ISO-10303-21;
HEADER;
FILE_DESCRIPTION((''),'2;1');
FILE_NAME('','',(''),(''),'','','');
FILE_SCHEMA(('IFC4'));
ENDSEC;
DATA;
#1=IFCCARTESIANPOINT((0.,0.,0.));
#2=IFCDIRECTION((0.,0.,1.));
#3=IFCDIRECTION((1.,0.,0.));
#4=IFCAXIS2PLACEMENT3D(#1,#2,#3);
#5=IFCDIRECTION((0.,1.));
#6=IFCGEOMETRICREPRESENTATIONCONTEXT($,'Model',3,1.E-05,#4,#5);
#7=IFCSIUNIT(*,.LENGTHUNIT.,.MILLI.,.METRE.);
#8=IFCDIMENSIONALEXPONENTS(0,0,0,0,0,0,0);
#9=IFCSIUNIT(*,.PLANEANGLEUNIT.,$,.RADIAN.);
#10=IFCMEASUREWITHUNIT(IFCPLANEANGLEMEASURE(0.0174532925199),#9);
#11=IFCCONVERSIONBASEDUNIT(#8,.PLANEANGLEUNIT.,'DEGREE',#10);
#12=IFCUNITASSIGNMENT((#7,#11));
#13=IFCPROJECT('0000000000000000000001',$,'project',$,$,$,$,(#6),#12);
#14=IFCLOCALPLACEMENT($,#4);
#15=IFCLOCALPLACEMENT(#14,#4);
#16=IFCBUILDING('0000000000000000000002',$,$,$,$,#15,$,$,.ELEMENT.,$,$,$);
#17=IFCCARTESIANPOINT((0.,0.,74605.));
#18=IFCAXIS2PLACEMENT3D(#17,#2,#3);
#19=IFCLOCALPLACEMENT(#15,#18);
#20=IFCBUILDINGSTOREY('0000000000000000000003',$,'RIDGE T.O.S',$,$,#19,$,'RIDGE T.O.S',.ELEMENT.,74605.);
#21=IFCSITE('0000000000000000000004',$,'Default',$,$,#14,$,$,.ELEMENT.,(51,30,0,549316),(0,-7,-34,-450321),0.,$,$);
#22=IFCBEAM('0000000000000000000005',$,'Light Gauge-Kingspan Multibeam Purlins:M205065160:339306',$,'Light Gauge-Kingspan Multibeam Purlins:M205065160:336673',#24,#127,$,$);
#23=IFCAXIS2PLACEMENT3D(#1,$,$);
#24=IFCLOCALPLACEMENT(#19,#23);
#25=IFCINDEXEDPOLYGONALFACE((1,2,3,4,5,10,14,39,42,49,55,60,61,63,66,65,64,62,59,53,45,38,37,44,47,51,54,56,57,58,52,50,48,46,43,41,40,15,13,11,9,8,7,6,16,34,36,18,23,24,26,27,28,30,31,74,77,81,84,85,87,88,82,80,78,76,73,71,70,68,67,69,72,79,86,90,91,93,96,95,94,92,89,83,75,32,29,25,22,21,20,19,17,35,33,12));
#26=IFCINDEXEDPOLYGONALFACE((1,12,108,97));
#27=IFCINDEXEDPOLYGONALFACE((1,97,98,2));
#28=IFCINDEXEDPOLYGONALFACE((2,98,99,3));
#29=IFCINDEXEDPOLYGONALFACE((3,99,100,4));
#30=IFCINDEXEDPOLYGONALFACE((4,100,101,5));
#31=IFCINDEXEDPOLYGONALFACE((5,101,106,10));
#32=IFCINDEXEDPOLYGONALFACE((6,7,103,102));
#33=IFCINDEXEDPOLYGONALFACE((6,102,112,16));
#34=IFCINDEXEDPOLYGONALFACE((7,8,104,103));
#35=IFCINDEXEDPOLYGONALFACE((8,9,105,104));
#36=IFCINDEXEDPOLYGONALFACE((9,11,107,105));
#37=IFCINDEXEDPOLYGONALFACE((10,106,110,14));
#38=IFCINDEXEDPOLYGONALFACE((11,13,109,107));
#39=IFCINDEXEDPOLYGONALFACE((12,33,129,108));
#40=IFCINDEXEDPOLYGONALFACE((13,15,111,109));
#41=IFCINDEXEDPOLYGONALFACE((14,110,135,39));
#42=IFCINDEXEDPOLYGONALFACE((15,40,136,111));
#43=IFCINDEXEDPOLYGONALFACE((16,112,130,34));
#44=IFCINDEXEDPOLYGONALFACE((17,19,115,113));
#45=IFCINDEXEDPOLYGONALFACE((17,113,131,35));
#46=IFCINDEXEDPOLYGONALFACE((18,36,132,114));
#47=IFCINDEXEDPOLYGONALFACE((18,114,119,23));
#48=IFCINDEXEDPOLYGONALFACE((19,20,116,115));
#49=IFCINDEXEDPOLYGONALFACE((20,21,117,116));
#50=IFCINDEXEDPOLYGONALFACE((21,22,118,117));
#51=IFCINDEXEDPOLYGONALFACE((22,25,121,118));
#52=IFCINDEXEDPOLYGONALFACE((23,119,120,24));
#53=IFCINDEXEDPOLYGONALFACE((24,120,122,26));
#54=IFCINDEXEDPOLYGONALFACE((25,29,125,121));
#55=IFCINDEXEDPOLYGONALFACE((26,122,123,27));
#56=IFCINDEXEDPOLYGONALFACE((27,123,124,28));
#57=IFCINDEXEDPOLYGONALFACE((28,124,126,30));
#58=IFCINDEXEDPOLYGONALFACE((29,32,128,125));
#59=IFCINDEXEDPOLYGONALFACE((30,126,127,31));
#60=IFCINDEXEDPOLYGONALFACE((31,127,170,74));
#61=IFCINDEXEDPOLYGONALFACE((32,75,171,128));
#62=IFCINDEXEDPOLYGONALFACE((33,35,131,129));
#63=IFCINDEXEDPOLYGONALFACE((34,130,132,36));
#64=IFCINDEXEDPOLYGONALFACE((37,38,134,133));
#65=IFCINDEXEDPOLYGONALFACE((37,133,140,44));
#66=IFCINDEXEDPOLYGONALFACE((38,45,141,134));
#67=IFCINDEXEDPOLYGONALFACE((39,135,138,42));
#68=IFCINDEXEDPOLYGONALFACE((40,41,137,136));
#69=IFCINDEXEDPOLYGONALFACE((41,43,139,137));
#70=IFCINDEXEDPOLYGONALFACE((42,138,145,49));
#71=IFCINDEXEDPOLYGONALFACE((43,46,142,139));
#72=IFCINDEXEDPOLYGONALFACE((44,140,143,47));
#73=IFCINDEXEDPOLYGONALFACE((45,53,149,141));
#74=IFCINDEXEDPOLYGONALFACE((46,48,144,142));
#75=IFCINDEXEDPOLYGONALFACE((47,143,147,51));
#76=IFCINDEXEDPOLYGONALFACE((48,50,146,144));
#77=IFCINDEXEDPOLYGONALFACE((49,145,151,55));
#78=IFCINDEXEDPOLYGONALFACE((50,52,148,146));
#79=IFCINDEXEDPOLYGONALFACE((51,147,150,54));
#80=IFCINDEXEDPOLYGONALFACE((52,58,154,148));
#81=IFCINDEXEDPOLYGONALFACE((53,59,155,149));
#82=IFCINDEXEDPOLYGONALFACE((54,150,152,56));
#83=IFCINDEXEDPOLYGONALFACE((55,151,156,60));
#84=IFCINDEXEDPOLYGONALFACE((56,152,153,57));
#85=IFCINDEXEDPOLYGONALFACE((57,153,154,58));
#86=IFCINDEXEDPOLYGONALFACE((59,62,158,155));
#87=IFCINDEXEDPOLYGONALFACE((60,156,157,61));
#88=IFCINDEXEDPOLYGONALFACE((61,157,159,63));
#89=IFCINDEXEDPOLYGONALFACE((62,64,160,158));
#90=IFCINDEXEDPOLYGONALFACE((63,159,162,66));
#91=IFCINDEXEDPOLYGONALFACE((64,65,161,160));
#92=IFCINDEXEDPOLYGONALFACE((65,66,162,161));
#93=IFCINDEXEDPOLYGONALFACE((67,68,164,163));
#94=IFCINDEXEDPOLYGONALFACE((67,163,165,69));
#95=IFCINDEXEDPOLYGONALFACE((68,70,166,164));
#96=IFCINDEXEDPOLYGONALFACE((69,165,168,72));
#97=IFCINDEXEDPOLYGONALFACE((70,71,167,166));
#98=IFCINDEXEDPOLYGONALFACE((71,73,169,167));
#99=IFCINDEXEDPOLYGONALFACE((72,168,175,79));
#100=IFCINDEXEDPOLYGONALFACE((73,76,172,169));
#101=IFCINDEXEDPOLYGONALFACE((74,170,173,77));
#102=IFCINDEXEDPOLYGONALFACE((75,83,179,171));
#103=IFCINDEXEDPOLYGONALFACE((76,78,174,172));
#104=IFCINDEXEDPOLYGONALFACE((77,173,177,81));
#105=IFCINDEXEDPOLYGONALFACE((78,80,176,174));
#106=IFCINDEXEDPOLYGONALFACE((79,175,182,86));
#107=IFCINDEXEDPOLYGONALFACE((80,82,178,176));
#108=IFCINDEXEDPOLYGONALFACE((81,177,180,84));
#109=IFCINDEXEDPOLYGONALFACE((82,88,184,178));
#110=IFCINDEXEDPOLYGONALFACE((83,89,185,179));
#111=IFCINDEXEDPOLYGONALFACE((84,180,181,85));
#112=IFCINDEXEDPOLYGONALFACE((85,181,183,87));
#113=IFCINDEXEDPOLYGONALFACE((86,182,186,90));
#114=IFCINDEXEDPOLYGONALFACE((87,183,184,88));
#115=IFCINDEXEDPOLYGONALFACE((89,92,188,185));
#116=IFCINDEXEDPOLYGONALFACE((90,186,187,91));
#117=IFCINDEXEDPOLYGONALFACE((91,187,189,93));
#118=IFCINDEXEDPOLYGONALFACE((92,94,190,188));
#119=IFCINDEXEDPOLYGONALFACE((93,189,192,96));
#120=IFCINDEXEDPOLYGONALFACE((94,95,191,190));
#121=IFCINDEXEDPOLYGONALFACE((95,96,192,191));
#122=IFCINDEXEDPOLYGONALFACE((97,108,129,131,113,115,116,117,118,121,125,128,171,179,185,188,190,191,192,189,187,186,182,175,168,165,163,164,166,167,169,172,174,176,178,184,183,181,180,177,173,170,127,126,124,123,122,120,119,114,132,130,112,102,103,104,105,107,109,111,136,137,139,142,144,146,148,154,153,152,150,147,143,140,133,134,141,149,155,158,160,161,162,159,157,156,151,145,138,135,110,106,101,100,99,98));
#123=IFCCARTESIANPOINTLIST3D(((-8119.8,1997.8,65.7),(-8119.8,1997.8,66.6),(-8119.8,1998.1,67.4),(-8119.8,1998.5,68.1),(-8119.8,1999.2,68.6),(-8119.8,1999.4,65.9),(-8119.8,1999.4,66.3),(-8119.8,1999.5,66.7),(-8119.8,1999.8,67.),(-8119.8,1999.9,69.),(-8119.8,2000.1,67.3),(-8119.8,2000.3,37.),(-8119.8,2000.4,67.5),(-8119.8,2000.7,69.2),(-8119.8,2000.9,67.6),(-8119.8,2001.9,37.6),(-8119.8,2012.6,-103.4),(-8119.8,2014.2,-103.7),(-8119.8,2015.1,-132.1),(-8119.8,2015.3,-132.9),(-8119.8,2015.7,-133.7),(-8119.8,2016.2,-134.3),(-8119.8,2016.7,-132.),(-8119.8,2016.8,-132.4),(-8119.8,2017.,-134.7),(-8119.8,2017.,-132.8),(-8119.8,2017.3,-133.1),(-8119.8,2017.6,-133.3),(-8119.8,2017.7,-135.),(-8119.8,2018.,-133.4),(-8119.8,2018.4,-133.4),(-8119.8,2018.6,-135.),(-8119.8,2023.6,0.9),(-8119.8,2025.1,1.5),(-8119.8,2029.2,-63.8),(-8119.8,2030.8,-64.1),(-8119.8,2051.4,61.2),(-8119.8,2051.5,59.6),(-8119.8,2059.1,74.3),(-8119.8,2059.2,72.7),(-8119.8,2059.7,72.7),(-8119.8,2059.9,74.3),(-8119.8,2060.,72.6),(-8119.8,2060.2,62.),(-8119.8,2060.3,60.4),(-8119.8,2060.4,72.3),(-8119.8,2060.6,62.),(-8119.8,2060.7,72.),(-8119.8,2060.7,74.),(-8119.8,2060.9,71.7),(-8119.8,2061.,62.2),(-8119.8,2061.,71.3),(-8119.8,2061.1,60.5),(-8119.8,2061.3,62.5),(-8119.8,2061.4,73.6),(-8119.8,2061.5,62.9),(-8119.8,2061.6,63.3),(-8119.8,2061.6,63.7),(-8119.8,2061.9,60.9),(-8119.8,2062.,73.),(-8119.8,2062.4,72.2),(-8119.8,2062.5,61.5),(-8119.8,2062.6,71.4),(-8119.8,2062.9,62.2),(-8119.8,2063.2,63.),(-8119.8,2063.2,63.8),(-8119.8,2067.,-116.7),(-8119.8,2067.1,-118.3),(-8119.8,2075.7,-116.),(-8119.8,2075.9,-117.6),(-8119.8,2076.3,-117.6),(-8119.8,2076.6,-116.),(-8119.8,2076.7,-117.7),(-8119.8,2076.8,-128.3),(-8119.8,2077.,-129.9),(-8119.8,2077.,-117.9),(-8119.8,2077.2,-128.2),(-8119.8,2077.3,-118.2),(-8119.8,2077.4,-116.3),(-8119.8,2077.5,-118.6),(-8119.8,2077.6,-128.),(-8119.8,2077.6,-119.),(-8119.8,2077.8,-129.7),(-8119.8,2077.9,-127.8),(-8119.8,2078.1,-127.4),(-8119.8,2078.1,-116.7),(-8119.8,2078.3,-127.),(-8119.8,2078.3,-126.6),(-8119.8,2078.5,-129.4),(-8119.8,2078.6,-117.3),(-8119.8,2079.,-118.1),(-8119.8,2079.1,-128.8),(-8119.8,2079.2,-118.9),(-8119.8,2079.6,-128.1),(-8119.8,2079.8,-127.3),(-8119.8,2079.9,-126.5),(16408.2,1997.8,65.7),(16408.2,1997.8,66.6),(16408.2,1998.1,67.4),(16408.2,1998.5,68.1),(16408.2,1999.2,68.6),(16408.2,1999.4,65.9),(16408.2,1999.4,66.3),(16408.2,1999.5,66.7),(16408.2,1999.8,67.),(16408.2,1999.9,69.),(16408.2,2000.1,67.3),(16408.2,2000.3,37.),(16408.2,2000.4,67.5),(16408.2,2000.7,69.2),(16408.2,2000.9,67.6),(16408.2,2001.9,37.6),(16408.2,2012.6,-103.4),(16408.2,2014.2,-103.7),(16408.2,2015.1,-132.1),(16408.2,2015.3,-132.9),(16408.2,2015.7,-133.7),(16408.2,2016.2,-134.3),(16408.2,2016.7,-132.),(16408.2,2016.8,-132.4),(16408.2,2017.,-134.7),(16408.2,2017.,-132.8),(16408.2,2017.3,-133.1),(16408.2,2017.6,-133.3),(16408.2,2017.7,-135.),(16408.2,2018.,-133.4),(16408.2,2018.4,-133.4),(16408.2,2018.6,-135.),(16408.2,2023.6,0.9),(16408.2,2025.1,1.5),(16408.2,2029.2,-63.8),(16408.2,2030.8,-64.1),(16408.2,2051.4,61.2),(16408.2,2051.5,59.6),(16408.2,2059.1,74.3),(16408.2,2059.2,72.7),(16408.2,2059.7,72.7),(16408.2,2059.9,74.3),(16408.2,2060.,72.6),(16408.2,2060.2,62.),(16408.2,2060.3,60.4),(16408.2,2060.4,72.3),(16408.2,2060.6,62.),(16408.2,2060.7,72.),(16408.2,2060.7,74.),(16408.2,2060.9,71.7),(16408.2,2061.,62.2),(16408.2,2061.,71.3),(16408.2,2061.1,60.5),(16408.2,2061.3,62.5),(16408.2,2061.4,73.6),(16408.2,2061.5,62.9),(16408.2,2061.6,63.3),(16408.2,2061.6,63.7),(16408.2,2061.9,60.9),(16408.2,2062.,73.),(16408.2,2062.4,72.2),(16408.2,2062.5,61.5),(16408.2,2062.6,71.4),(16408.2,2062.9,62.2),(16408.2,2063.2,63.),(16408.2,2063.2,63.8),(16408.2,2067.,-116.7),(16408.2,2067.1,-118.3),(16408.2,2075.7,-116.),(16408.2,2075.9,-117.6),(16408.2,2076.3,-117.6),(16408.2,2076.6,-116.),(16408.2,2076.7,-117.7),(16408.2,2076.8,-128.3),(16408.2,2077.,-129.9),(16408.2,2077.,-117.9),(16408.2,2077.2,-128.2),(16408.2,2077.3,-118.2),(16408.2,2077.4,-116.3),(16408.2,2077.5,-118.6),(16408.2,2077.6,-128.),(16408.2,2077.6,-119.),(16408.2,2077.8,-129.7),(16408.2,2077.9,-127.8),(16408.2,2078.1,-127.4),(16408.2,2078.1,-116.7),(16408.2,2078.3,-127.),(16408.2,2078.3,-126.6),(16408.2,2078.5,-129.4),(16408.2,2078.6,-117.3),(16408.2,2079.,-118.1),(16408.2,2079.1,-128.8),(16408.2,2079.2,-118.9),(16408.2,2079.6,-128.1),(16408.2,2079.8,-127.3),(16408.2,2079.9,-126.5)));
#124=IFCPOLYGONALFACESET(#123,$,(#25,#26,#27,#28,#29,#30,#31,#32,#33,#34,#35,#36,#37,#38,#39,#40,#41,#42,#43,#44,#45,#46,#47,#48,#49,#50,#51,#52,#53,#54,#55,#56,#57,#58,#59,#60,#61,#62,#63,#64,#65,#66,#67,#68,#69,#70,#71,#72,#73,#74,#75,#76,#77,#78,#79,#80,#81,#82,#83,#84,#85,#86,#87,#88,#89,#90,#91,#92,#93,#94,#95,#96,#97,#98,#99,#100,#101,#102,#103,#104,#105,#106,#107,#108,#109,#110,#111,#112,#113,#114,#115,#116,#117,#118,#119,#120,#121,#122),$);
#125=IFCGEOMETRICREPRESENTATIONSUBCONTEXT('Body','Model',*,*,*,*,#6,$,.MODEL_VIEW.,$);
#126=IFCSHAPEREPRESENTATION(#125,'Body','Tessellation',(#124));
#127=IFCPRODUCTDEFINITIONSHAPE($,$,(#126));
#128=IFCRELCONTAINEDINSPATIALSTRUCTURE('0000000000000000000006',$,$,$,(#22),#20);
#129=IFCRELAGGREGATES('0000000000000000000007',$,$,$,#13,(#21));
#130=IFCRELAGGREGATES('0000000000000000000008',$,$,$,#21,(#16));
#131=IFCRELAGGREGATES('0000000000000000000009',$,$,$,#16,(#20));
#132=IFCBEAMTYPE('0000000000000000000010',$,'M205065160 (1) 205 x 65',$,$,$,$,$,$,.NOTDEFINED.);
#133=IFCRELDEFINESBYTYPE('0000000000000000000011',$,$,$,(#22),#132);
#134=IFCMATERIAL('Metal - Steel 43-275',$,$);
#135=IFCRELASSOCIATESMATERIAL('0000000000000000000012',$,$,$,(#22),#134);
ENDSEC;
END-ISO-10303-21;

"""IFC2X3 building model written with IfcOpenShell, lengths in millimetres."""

from ifc_helpers import new_model, entity, si_unit, converted_unit, point, direction, frame, frame_2d, origin_with_axes, place, context, subcontext, project, spatial, polyline, circle_curve, parameter, trimmed, segment, composite_curve, outline, extrude, material, type_object, element, save


model = new_model("IFC2X3")

# Units and contexts
model_context = context("Model", 3, precision=1e-05, world=origin_with_axes(), true_north=direction((0.0, 1.0)))
body_context = subcontext(model_context, "Body", "Model", "MODEL_VIEW")
ifc_project = project(units=[si_unit("LENGTHUNIT", "METRE", prefix="MILLI"), converted_unit("PLANEANGLEUNIT", "DEGREE", entity("IfcPlaneAngleMeasure", 0.0174532925199), si_unit("PLANEANGLEUNIT", "RADIAN"), dimensions=[0, 0, 0, 0, 0, 0, 0])], contexts=[model_context])

# Site, building, storey
site_placement = place(None, origin_with_axes())
site = spatial("IfcSite", under=ifc_project, at=site_placement, Name="Default", CompositionType="ELEMENT", RefLatitude=(51, 30, 0, 549316), RefLongitude=(0, -7, -34, -450321), RefElevation=0.0)
building_placement = place(site_placement, origin_with_axes())
building = spatial("IfcBuilding", under=site, at=building_placement, CompositionType="ELEMENT")
storey_placement = place(building_placement, frame((0.0, 0.0, 74605.0), z_axis=(0.0, 0.0, 1.0), x_axis=(1.0, 0.0, 0.0)))
storey = spatial("IfcBuildingStorey", under=building, at=storey_placement, Name="RIDGE T.O.S", LongName="RIDGE T.O.S", CompositionType="ELEMENT", Elevation=74605.0)

# Beam
ifc_material = material(Name="Metal - Steel 43-275")
beam_type_1 = type_object("IfcBeamType", Name="M205065160 (1) 205 x 65", PredefinedType="NOTDEFINED")
beam_1_placement = place(storey_placement, frame((16408.2, 2043.1, -30.0), z_axis=(0.0, 0.0, 1.0), x_axis=(0.0, 1.0, 0.0)))
element("IfcBeam", 1, at=beam_1_placement, inside=storey, type_object=beam_type_1, material=ifc_material, Name="Light Gauge-Kingspan Multibeam Purlins:M205065160:339306", ObjectType="Light Gauge-Kingspan Multibeam Purlins:M205065160:336673", context=body_context, shape_type="SweptSolid", body=[
    extrude(outline(composite_curve([segment(polyline([(91.7, -28.3), (99.3, -28.3)]), True, "CONTINUOUS"), segment(trimmed(circle_curve(frame_2d((99.3, -25.1), x_axis=(0.0, -1.0)), 3.2), [point((99.3, -28.3)), parameter(0.0)], [point((102.5, -25.1)), parameter(90.0)], True, "CARTESIAN"), True, "CONTINUOUS"), segment(polyline([(102.5, -25.1), (102.5, 33.5)]), True, "CONTINUOUS"), segment(trimmed(circle_curve(frame_2d((99.3, 33.5), x_axis=(1.0, 0.0)), 3.2), [point((102.5, 33.5)), parameter(0.0)], [point((99.3, 36.7)), parameter(90.0)], True, "CARTESIAN"), True, "CONTINUOUS"), segment(polyline([(99.3, 36.7), (70.5, 36.7), (32.5, 16.7), (-32.5, 16.7), (-70.5, 36.7), (-99.3, 36.7)]), True, "CONTINUOUS"), segment(trimmed(circle_curve(frame_2d((-99.3, 33.5), x_axis=(0.0, 1.0)), 3.2), [point((-99.3, 36.7)), parameter(0.0)], [point((-102.5, 33.5)), parameter(90.0)], True, "CARTESIAN"), True, "CONTINUOUS"), segment(polyline([(-102.5, 33.5), (-102.5, -25.1)]), True, "CONTINUOUS"), segment(trimmed(circle_curve(frame_2d((-99.3, -25.1), x_axis=(-1.0, 0.0)), 3.2), [point((-102.5, -25.1)), parameter(0.0)], [point((-99.3, -28.3)), parameter(90.0)], True, "CARTESIAN"), True, "CONTINUOUS"), segment(polyline([(-99.3, -28.3), (-91.7, -28.3)]), True, "CONTINUOUS"), segment(trimmed(circle_curve(frame_2d((-91.7, -25.1), x_axis=(0.0, -1.0)), 3.2), [point((-91.7, -28.3)), parameter(0.0)], [point((-88.5, -25.1)), parameter(90.0)], True, "CARTESIAN"), True, "CONTINUOUS"), segment(polyline([(-88.5, -25.1), (-88.5, -16.3), (-90.1, -16.3), (-90.1, -25.1)]), True, "CONTINUOUS"), segment(trimmed(circle_curve(frame_2d((-91.7, -25.1), x_axis=(0.0, -1.0)), 1.6), [point((-90.1, -25.1)), parameter(90.0)], [point((-91.7, -26.7)), parameter(0.0)], False, "CARTESIAN"), True, "CONTINUOUS"), segment(polyline([(-91.7, -26.7), (-99.3, -26.7)]), True, "CONTINUOUS"), segment(trimmed(circle_curve(frame_2d((-99.3, -25.1), x_axis=(-1.0, 0.0)), 1.6), [point((-99.3, -26.7)), parameter(90.0)], [point((-100.9, -25.1)), parameter(0.0)], False, "CARTESIAN"), True, "CONTINUOUS"), segment(polyline([(-100.9, -25.1), (-100.9, 33.5)]), True, "CONTINUOUS"), segment(trimmed(circle_curve(frame_2d((-99.3, 33.5), x_axis=(0.0, 1.0)), 1.6), [point((-100.9, 33.5)), parameter(90.0)], [point((-99.3, 35.1)), parameter(0.0)], False, "CARTESIAN"), True, "CONTINUOUS"), segment(polyline([(-99.3, 35.1), (-70.9, 35.1), (-32.9, 15.1), (32.9, 15.1), (70.9, 35.1), (99.3, 35.1)]), True, "CONTINUOUS"), segment(trimmed(circle_curve(frame_2d((99.3, 33.5), x_axis=(1.0, 0.0)), 1.6), [point((99.3, 35.1)), parameter(90.0)], [point((100.9, 33.5)), parameter(0.0)], False, "CARTESIAN"), True, "CONTINUOUS"), segment(polyline([(100.9, 33.5), (100.9, -25.1)]), True, "CONTINUOUS"), segment(trimmed(circle_curve(frame_2d((99.3, -25.1), x_axis=(0.0, -1.0)), 1.6), [point((100.9, -25.1)), parameter(90.0)], [point((99.3, -26.7)), parameter(0.0)], False, "CARTESIAN"), True, "CONTINUOUS"), segment(polyline([(99.3, -26.7), (91.7, -26.7)]), True, "CONTINUOUS"), segment(trimmed(circle_curve(frame_2d((91.7, -25.1), x_axis=(-1.0, 0.0)), 1.6), [point((91.7, -26.7)), parameter(90.0)], [point((90.1, -25.1)), parameter(0.0)], False, "CARTESIAN"), True, "CONTINUOUS"), segment(polyline([(90.1, -25.1), (90.1, -16.3), (88.5, -16.3), (88.5, -25.1)]), True, "CONTINUOUS"), segment(trimmed(circle_curve(frame_2d((91.7, -25.1), x_axis=(-1.0, 0.0)), 3.2), [point((88.5, -25.1)), parameter(0.0)], [point((91.7, -28.3)), parameter(90.0)], True, "CARTESIAN"), True, "CONTINUOUS")], self_intersect=False)), frame((0.0, 24528.0, 0.0), z_axis=(0.0, -1.0, 0.0), x_axis=(-0.087156, 0.0, 0.996195)), (0.0, 0.0, 1.0), 24528.0),
])

save(model, "model.ifc")
